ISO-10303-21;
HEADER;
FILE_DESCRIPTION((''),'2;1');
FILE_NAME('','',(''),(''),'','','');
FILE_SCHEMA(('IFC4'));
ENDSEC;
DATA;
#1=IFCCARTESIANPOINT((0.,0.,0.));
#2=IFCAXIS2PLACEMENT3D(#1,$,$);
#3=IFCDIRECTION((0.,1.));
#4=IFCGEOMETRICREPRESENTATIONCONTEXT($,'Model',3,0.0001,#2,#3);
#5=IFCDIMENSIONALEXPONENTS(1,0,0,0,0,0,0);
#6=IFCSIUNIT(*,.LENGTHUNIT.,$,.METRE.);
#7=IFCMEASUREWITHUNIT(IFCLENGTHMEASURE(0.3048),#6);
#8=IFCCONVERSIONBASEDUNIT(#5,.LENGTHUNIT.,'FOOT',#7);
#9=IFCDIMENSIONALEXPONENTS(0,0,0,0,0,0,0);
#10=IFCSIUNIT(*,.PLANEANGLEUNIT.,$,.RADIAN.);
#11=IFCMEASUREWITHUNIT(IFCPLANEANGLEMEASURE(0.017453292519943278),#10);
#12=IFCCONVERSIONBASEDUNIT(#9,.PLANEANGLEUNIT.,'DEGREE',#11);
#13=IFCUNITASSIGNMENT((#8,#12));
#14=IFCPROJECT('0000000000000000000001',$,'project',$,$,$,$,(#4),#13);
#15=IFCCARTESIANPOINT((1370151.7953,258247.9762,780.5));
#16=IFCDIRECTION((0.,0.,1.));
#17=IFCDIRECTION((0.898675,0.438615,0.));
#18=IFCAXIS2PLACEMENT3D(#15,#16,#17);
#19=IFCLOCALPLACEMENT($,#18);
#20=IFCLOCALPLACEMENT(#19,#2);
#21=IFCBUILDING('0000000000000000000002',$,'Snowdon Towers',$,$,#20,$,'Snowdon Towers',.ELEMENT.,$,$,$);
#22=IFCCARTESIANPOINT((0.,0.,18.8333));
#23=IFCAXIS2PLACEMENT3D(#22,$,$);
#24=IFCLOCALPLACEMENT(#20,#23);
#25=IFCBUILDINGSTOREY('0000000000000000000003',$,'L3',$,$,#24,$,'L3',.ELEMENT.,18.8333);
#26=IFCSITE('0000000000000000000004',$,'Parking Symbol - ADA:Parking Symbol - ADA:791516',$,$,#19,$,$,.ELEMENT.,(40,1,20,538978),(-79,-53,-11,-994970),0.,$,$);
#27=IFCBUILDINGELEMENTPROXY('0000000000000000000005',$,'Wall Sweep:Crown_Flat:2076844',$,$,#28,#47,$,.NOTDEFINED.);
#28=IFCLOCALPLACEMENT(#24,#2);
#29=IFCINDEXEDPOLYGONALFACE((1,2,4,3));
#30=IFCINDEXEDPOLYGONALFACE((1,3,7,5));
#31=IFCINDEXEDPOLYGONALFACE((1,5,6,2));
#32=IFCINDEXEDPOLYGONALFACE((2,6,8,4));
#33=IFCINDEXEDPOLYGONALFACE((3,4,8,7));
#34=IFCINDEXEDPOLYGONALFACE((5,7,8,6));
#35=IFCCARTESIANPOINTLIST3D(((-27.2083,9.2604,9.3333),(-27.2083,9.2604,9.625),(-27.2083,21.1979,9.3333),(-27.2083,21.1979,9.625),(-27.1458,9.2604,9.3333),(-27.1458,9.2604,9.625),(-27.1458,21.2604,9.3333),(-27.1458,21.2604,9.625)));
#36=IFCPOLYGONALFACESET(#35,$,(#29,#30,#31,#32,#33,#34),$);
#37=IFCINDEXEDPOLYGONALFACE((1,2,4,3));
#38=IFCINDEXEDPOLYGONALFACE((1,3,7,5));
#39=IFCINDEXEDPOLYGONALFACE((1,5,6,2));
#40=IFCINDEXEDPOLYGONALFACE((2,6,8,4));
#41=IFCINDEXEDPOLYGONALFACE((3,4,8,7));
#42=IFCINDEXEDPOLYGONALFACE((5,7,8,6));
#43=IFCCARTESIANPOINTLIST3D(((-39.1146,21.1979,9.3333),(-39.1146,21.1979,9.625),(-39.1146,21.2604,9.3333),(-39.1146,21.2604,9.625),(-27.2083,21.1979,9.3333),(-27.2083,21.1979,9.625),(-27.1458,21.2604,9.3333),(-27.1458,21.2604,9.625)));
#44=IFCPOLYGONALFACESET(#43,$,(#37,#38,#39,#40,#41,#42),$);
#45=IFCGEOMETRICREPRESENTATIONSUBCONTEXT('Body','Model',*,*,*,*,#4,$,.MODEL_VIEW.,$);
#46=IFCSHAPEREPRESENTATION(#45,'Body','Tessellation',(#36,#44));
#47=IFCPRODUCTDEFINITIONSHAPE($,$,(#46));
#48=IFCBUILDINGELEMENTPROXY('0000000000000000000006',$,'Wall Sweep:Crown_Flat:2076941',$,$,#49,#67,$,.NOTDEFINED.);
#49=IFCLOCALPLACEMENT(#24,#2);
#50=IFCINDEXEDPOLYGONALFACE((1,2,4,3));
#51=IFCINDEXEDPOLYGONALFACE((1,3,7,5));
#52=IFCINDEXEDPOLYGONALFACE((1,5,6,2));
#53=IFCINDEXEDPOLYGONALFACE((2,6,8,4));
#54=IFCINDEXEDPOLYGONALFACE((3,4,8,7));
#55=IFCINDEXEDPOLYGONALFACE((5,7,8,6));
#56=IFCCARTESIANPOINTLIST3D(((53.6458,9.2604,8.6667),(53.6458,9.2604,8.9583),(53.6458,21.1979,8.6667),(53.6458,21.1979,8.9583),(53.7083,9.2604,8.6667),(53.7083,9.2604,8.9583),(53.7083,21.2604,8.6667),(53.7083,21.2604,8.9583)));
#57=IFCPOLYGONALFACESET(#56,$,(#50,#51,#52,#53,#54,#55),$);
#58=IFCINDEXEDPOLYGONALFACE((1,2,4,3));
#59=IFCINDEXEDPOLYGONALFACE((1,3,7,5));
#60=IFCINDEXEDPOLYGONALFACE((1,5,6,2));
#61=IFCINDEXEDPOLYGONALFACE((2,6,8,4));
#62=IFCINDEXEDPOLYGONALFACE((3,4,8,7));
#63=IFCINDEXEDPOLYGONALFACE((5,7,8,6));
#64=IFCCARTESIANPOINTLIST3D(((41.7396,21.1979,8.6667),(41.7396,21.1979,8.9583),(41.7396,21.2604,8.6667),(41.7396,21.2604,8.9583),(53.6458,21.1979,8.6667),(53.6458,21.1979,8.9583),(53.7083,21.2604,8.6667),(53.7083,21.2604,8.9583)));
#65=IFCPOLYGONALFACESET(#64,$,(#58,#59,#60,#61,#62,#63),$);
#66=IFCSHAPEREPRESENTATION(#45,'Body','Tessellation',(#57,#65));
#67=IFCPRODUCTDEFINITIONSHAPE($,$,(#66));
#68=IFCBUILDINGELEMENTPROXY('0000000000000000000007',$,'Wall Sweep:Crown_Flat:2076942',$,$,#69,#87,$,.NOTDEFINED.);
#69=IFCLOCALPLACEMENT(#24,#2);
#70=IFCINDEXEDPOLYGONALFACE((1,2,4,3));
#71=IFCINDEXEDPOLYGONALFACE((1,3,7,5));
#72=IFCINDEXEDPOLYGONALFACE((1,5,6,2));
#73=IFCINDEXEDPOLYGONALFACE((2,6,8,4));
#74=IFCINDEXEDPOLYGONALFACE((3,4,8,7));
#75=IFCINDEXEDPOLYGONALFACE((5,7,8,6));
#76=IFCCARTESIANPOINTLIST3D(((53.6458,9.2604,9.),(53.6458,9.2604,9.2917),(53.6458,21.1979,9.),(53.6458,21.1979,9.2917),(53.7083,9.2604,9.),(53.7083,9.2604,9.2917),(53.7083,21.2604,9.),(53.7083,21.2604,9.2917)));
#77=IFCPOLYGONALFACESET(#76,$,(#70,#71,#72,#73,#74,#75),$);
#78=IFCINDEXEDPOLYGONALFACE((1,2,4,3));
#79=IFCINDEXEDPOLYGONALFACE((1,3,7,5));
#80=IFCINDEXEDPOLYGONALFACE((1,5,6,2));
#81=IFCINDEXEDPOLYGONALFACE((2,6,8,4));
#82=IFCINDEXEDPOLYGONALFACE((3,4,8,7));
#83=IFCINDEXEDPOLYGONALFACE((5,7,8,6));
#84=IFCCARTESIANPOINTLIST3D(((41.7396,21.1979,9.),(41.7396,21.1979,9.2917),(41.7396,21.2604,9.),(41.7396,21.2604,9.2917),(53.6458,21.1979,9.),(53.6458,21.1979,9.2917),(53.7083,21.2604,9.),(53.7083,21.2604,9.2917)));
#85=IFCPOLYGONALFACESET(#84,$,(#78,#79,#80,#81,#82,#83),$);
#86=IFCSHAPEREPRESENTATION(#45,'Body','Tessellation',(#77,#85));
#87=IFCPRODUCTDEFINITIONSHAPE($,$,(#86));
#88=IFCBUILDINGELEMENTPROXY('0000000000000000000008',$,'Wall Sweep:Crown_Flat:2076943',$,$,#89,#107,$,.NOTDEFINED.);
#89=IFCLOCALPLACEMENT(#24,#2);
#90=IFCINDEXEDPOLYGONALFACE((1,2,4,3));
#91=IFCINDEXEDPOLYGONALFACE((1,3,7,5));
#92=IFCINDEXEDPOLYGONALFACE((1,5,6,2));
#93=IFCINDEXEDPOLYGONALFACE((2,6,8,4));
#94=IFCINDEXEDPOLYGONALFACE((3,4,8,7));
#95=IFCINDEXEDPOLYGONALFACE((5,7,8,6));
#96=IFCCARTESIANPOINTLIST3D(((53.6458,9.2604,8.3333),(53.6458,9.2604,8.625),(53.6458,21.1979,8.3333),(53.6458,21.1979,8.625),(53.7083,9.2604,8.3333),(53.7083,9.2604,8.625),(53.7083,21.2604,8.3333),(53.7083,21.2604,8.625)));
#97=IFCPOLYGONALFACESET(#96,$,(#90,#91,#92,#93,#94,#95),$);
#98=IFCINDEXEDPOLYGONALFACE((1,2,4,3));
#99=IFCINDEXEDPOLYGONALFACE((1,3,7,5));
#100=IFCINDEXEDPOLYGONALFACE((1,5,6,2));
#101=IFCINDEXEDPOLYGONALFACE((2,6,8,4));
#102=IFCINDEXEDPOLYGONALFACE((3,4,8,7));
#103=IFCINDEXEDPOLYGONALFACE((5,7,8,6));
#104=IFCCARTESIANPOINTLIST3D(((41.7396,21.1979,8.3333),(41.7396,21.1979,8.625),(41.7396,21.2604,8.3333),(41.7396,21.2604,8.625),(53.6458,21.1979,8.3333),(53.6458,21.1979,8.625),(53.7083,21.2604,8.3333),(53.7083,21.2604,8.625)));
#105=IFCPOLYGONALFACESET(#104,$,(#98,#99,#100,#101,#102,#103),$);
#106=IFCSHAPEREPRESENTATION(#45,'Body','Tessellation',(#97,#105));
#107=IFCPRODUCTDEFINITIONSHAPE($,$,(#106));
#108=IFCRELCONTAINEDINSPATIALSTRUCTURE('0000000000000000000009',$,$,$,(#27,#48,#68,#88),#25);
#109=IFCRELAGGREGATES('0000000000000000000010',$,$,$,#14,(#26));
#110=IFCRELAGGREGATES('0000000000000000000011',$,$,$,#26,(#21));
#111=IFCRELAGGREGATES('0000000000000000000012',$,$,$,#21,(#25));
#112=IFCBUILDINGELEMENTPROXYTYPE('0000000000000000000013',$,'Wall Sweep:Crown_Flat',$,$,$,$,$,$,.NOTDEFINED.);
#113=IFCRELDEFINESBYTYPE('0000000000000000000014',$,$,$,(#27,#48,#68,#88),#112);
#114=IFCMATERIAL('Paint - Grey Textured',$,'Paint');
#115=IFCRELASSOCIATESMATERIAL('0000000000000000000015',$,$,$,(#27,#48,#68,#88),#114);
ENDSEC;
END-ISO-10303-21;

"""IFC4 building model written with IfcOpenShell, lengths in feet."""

from ifc_helpers import new_model, entity, si_unit, converted_unit, direction, frame, origin, place, context, subcontext, project, spatial, indexed_curve, outline, extrude, material, type_object, element, save


model = new_model("IFC4")

# Units and contexts
model_context = context("Model", 3, precision=0.0001, world=origin(), true_north=direction((0.0, 1.0)))
body_context = subcontext(model_context, "Body", "Model", "MODEL_VIEW")
ifc_project = project(units=[converted_unit("LENGTHUNIT", "FOOT", entity("IfcLengthMeasure", 0.3048), si_unit("LENGTHUNIT", "METRE"), dimensions=[1, 0, 0, 0, 0, 0, 0]), converted_unit("PLANEANGLEUNIT", "DEGREE", entity("IfcPlaneAngleMeasure", 0.017453292519943278), si_unit("PLANEANGLEUNIT", "RADIAN"), dimensions=[0, 0, 0, 0, 0, 0, 0])], contexts=[model_context])

# Site, building, storey
site_placement = place(None, frame((1370151.7953, 258247.9762, 780.5), z_axis=(0.0, 0.0, 1.0), x_axis=(0.898675, 0.438615, 0.0)))
site = spatial("IfcSite", under=ifc_project, at=site_placement, Name="Parking Symbol - ADA:Parking Symbol - ADA:791516", CompositionType="ELEMENT", RefLatitude=(40, 1, 20, 538978), RefLongitude=(-79, -53, -11, -994970), RefElevation=0.0)
building_placement = place(site_placement, origin())
building = spatial("IfcBuilding", under=site, at=building_placement, Name="Snowdon Towers", LongName="Snowdon Towers", CompositionType="ELEMENT")
storey_placement = place(building_placement, frame((0.0, 0.0, 18.8333)))
storey = spatial("IfcBuildingStorey", under=building, at=storey_placement, Name="L3", LongName="L3", CompositionType="ELEMENT", Elevation=18.8333)

# Building element proxies
ifc_material_1 = material(Name="Paint - Grey Textured", Category="Paint")
building_element_proxy_type = type_object("IfcBuildingElementProxyType", Name="Wall Sweep:Crown_Flat", PredefinedType="NOTDEFINED")
proxy_1_placement = place(storey_placement, origin())
element("IfcBuildingElementProxy", 1, at=proxy_1_placement, inside=storey, type_object=building_element_proxy_type, material=ifc_material_1, Name="Wall Sweep:Crown_Flat:2076844", PredefinedType="NOTDEFINED", context=body_context, shape_type="SweptSolid", body=[
    extrude(outline(indexed_curve([(-5.9531, -0.0312), (5.9844, -0.0312), (5.9844, 0.0312), (-6.0156, 0.0312), (-5.9531, -0.0312)], self_intersect=False)), frame((-27.1771, 15.2448, 9.3333), z_axis=(0.0, 0.0, 1.0), x_axis=(0.0, -1.0, 0.0)), (0.0, 0.0, 1.0), 0.2917),
    extrude(outline(indexed_curve([(-5.9688, -0.0312), (5.9375, -0.0312), (6.0, 0.0313), (-5.9688, 0.0313), (-5.9688, -0.0312)], self_intersect=False)), frame((-33.1458, 21.2292, 9.3333)), (0.0, 0.0, 1.0), 0.2917),
])
proxy_2_placement = place(storey_placement, origin())
element("IfcBuildingElementProxy", 2, at=proxy_2_placement, inside=storey, type_object=building_element_proxy_type, material=ifc_material_1, Name="Wall Sweep:Crown_Flat:2076941", PredefinedType="NOTDEFINED", context=body_context, shape_type="SweptSolid", body=[
    extrude(outline(indexed_curve([(-5.9531, -0.0312), (5.9844, -0.0312), (5.9844, 0.0312), (-6.0156, 0.0312), (-5.9531, -0.0312)], self_intersect=False)), frame((53.6771, 15.2448, 8.6667), z_axis=(0.0, 0.0, 1.0), x_axis=(0.0, -1.0, 0.0)), (0.0, 0.0, 1.0), 0.2917),
    extrude(outline(indexed_curve([(-5.9688, -0.0312), (5.9375, -0.0312), (6.0, 0.0313), (-5.9688, 0.0313), (-5.9688, -0.0312)], self_intersect=False)), frame((47.7083, 21.2292, 8.6667)), (0.0, 0.0, 1.0), 0.2917),
])
proxy_3_placement = place(storey_placement, origin())
element("IfcBuildingElementProxy", 3, at=proxy_3_placement, inside=storey, type_object=building_element_proxy_type, material=ifc_material_1, Name="Wall Sweep:Crown_Flat:2076942", PredefinedType="NOTDEFINED", context=body_context, shape_type="SweptSolid", body=[
    extrude(outline(indexed_curve([(-5.9531, -0.0312), (5.9844, -0.0312), (5.9844, 0.0312), (-6.0156, 0.0312), (-5.9531, -0.0312)], self_intersect=False)), frame((53.6771, 15.2448, 9.0), z_axis=(0.0, 0.0, 1.0), x_axis=(0.0, -1.0, 0.0)), (0.0, 0.0, 1.0), 0.2917),
    extrude(outline(indexed_curve([(-5.9688, -0.0312), (5.9375, -0.0312), (6.0, 0.0313), (-5.9688, 0.0313), (-5.9688, -0.0312)], self_intersect=False)), frame((47.7083, 21.2292, 9.0)), (0.0, 0.0, 1.0), 0.2917),
])
proxy_4_placement = place(storey_placement, origin())
element("IfcBuildingElementProxy", 4, at=proxy_4_placement, inside=storey, type_object=building_element_proxy_type, material=ifc_material_1, Name="Wall Sweep:Crown_Flat:2076943", PredefinedType="NOTDEFINED", context=body_context, shape_type="SweptSolid", body=[
    extrude(outline(indexed_curve([(-5.9531, -0.0312), (5.9844, -0.0312), (5.9844, 0.0312), (-6.0156, 0.0312), (-5.9531, -0.0312)], self_intersect=False)), frame((53.6771, 15.2448, 8.3333), z_axis=(0.0, 0.0, 1.0), x_axis=(0.0, -1.0, 0.0)), (0.0, 0.0, 1.0), 0.2917),
    extrude(outline(indexed_curve([(-5.9688, -0.0312), (5.9375, -0.0312), (6.0, 0.0313), (-5.9688, 0.0313), (-5.9688, -0.0312)], self_intersect=False)), frame((47.7083, 21.2292, 8.3333)), (0.0, 0.0, 1.0), 0.2917),
])

save(model, "model.ifc")
